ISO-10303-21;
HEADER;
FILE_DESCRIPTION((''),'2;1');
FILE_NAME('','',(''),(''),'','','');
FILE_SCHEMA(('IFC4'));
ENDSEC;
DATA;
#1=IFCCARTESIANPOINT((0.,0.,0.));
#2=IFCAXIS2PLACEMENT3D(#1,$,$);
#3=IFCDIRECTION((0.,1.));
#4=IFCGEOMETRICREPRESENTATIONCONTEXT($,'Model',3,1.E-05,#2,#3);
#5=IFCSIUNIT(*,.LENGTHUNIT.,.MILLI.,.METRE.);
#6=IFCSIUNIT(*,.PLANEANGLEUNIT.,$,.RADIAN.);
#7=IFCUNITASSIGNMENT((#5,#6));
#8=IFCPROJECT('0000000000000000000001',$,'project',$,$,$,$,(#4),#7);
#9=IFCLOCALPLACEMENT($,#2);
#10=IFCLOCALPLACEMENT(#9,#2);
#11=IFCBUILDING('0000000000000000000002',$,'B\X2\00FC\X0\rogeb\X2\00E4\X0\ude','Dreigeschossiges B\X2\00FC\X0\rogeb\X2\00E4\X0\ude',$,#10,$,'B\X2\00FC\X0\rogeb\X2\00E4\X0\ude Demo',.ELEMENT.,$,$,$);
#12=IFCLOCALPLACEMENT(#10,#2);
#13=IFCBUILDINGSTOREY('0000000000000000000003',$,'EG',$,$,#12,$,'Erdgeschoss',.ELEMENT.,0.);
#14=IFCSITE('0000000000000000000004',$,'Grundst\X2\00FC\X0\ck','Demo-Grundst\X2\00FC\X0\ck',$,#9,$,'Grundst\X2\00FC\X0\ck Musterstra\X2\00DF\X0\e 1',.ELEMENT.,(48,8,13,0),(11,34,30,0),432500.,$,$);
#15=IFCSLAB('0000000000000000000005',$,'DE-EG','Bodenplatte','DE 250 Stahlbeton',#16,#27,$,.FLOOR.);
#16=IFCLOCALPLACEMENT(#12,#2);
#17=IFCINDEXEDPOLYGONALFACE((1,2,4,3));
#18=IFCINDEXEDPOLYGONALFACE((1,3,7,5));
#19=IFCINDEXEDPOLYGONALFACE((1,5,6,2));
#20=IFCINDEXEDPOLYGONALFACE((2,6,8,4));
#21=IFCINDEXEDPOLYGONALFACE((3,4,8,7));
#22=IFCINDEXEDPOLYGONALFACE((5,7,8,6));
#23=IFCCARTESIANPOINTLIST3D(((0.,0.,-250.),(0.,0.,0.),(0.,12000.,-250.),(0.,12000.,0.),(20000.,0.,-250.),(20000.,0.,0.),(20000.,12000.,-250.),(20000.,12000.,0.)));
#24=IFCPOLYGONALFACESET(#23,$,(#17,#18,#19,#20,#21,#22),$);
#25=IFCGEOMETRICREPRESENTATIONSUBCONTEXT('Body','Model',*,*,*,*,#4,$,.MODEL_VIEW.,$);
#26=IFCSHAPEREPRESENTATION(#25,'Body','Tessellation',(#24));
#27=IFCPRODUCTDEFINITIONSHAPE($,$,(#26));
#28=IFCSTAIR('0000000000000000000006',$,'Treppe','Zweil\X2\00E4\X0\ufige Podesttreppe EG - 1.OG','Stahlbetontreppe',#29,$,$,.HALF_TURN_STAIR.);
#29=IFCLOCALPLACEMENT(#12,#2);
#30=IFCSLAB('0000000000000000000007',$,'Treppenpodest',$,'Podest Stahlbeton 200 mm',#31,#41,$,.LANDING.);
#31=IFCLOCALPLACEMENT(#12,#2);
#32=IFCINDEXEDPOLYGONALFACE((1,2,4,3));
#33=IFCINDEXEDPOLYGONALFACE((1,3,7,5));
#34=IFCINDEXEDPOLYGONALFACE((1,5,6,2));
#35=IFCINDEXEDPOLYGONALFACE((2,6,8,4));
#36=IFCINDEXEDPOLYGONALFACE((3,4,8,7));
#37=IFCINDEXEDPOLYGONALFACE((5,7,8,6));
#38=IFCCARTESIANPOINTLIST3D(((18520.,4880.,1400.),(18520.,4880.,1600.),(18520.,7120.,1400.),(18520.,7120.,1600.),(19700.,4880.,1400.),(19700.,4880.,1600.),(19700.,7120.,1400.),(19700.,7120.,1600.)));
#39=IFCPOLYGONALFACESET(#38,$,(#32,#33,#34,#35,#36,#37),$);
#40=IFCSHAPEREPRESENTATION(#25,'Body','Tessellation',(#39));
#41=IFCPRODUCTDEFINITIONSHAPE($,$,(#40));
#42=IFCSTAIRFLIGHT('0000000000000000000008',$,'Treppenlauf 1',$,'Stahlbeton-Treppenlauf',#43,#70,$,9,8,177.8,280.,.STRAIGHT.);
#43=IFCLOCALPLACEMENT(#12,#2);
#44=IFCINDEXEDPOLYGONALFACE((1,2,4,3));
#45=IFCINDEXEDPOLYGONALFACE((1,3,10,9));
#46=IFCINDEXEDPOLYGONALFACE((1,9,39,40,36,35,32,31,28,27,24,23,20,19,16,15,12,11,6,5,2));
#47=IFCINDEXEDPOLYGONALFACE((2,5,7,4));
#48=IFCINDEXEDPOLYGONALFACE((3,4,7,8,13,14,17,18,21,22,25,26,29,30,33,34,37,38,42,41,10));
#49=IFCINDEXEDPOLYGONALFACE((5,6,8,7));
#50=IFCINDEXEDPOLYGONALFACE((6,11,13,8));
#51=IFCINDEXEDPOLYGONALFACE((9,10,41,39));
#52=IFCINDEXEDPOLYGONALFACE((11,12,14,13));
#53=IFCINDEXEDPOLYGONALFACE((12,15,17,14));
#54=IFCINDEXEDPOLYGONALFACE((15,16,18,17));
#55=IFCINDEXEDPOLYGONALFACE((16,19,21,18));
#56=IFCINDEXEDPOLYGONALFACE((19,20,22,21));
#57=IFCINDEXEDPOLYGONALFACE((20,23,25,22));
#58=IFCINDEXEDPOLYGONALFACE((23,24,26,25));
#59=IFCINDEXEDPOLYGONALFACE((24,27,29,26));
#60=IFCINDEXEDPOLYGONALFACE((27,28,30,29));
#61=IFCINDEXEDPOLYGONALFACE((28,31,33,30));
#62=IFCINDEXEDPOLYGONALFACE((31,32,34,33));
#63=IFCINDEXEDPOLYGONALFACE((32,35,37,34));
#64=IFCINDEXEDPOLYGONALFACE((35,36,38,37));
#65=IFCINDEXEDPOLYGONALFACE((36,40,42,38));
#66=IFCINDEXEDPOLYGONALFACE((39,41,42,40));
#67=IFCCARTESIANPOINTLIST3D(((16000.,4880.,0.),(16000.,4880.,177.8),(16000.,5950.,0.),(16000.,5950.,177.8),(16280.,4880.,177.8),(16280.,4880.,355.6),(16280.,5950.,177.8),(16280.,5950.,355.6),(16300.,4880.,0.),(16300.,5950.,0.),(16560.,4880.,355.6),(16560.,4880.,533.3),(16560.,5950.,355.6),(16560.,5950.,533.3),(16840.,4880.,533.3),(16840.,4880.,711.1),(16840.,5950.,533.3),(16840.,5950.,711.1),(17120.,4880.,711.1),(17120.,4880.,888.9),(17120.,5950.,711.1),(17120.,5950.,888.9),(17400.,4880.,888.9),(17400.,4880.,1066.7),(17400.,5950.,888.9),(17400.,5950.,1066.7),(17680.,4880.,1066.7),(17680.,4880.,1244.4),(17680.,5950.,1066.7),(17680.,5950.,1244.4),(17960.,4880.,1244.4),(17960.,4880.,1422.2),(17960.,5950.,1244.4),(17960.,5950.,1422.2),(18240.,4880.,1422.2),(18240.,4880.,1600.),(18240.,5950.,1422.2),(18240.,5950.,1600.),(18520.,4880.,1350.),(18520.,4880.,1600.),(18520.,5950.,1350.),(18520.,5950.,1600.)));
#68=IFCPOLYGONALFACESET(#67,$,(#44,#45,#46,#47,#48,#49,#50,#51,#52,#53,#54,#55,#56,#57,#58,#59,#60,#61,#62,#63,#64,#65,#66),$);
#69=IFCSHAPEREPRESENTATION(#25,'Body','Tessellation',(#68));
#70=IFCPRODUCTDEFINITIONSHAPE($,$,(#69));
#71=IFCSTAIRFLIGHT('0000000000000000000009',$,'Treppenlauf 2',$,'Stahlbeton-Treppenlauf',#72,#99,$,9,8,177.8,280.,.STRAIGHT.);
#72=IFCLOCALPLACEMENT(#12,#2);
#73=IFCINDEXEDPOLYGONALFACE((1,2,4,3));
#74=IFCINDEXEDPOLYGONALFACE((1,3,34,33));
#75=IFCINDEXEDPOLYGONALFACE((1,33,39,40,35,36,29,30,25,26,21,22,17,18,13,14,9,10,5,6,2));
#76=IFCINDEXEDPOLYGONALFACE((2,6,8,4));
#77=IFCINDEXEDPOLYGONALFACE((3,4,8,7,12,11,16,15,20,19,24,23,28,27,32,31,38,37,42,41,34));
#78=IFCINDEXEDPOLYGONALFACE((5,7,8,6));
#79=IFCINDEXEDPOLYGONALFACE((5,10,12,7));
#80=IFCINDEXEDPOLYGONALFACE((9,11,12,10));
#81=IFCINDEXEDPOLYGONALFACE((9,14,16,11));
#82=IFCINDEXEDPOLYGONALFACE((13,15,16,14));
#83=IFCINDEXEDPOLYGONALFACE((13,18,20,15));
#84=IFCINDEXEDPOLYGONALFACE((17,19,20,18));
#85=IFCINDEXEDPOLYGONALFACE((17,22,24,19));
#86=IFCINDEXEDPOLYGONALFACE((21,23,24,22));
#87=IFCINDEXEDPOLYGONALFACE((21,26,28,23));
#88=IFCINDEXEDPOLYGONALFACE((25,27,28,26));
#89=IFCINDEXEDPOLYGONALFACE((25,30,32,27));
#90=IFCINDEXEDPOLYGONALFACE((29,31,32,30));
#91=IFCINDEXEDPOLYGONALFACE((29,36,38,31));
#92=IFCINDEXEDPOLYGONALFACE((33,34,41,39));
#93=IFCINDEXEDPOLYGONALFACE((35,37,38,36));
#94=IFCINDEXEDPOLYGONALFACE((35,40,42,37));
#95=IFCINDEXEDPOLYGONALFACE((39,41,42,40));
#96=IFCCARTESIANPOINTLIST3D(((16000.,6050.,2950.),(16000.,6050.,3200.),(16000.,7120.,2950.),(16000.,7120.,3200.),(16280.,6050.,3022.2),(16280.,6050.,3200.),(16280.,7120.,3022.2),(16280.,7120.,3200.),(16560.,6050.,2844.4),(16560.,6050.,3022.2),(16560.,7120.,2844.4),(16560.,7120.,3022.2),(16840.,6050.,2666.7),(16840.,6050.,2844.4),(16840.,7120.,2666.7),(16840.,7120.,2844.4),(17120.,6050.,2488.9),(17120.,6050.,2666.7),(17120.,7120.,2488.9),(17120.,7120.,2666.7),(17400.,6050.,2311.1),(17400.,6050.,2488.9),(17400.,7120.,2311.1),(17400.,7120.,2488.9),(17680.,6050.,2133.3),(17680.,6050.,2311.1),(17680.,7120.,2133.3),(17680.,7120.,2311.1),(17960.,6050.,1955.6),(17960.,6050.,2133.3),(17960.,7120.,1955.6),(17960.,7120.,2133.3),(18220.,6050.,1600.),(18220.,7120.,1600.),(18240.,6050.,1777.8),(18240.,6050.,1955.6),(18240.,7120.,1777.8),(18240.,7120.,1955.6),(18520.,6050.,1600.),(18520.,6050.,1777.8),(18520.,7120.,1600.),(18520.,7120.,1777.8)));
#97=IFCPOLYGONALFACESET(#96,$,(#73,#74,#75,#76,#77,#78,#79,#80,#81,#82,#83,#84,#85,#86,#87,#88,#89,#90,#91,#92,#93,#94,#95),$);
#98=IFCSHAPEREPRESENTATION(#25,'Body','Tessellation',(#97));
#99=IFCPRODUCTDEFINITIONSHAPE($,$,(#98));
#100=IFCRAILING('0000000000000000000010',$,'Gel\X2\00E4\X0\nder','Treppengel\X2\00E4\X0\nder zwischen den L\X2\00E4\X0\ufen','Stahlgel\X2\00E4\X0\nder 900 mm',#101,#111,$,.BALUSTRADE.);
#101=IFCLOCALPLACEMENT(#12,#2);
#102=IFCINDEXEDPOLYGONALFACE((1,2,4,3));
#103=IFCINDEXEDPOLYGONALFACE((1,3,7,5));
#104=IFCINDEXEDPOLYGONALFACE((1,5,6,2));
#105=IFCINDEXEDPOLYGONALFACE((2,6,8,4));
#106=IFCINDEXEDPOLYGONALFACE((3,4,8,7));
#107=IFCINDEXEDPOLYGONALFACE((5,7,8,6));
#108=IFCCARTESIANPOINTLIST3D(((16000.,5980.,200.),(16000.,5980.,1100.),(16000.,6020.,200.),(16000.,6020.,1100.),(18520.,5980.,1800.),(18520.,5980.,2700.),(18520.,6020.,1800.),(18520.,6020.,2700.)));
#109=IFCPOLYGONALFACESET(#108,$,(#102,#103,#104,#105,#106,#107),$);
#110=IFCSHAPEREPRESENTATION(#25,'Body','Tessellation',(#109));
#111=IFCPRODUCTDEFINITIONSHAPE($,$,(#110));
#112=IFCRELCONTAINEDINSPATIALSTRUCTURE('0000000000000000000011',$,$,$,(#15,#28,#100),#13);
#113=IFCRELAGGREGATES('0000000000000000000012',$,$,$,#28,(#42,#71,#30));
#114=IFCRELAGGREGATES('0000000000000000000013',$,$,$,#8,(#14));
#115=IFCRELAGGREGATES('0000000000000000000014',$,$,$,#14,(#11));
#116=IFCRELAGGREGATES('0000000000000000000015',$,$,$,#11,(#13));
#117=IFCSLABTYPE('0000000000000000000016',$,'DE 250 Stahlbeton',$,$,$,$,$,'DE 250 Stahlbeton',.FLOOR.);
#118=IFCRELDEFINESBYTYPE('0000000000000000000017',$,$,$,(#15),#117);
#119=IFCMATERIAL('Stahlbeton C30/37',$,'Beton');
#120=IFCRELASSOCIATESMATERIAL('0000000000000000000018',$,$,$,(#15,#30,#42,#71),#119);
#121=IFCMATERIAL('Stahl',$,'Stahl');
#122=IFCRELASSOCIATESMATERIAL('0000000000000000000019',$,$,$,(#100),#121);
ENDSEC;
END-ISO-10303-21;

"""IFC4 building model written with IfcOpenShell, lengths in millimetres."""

from ifc_helpers import new_model, si_unit, direction, frame, frame_2d, origin, place, context, subcontext, project, spatial, polyline, rectangle, outline, extrude, material, type_object, element, aggregate, save


model = new_model("IFC4")

# Units and contexts
model_context = context("Model", 3, precision=1e-05, world=origin(), true_north=direction((0.0, 1.0)))
body_context = subcontext(model_context, "Body", "Model", "MODEL_VIEW")
ifc_project = project(units=[si_unit("LENGTHUNIT", "METRE", prefix="MILLI"), si_unit("PLANEANGLEUNIT", "RADIAN")], contexts=[model_context])

# Site, building, storey
site_placement = place(None, origin())
site = spatial("IfcSite", under=ifc_project, at=site_placement, Name="Grundstück", Description="Demo-Grundstück", LongName="Grundstück Musterstraße 1", CompositionType="ELEMENT", RefLatitude=(48, 8, 13, 0), RefLongitude=(11, 34, 30, 0), RefElevation=432500.0)
building_placement = place(site_placement, origin())
building = spatial("IfcBuilding", under=site, at=building_placement, Name="Bürogebäude", Description="Dreigeschossiges Bürogebäude", LongName="Bürogebäude Demo", CompositionType="ELEMENT")
storey_placement = place(building_placement, origin())
storey = spatial("IfcBuildingStorey", under=building, at=storey_placement, Name="EG", LongName="Erdgeschoss", CompositionType="ELEMENT", Elevation=0.0)

# Slab
ifc_material_1 = material(Name="Stahlbeton C30/37", Category="Beton")
slab_type = type_object("IfcSlabType", Name="DE 250 Stahlbeton", ElementType="DE 250 Stahlbeton", PredefinedType="FLOOR")
slab_1_placement = place(storey_placement, origin())
element("IfcSlab", 1, at=slab_1_placement, inside=storey, type_object=slab_type, material=ifc_material_1, Name="DE-EG", Description="Bodenplatte", ObjectType="DE 250 Stahlbeton", PredefinedType="FLOOR", context=body_context, shape_type="SweptSolid", body=[
    extrude(rectangle(XDim=20000.0, YDim=12000.0, at=frame_2d((10000.0, 6000.0))), frame((0.0, 0.0, -250.0)), (0.0, 0.0, 1.0), 250.0),
])

# Stair, slab, stair flights
stair_placement = place(storey_placement, origin())
stair = element("IfcStair", 2, at=stair_placement, inside=storey, Name="Treppe", Description="Zweiläufige Podesttreppe EG - 1.OG", ObjectType="Stahlbetontreppe", PredefinedType="HALF_TURN_STAIR")
slab_2_placement = place(stair_placement, origin())
slab_2 = element("IfcSlab", 3, at=slab_2_placement, material=ifc_material_1, Name="Treppenpodest", ObjectType="Podest Stahlbeton 200 mm", PredefinedType="LANDING", context=body_context, shape_type="SweptSolid", body=[
    extrude(rectangle(XDim=1180.0, YDim=2240.0, at=frame_2d((19110.0, 6000.0))), frame((0.0, 0.0, 1400.0)), (0.0, 0.0, 1.0), 200.0),
])
stair_flight_1_placement = place(stair_placement, origin())
stair_flight_1 = element("IfcStairFlight", 4, at=stair_flight_1_placement, material=ifc_material_1, Name="Treppenlauf 1", ObjectType="Stahlbeton-Treppenlauf", NumberOfRisers=9, NumberOfTreads=8, PredefinedType="STRAIGHT", RiserHeight=177.8, TreadLength=280.0, context=body_context, shape_type="SweptSolid", body=[
    extrude(outline(polyline([(16300.0, 0.0), (18520.0, 1350.0), (18520.0, 1600.0), (18240.0, 1600.0), (18240.0, 1422.2), (17960.0, 1422.2), (17960.0, 1244.4), (17680.0, 1244.4), (17680.0, 1066.7), (17400.0, 1066.7), (17400.0, 888.9), (17120.0, 888.9), (17120.0, 711.1), (16840.0, 711.1), (16840.0, 533.3), (16560.0, 533.3), (16560.0, 355.6), (16280.0, 355.6), (16280.0, 177.8), (16000.0, 177.8), (16000.0, 0.0), (16300.0, 0.0)])), frame((0.0, 5950.0, 0.0), z_axis=(0.0, -1.0, 0.0), x_axis=(1.0, 0.0, 0.0)), (0.0, 0.0, 1.0), 1070.0),
])
stair_flight_2_placement = place(stair_placement, origin())
stair_flight_2 = element("IfcStairFlight", 5, at=stair_flight_2_placement, material=ifc_material_1, Name="Treppenlauf 2", ObjectType="Stahlbeton-Treppenlauf", NumberOfRisers=9, NumberOfTreads=8, PredefinedType="STRAIGHT", RiserHeight=177.8, TreadLength=280.0, context=body_context, shape_type="SweptSolid", body=[
    extrude(outline(polyline([(18520.0, 1600.0), (18520.0, 1777.8), (18240.0, 1777.8), (18240.0, 1955.6), (17960.0, 1955.6), (17960.0, 2133.3), (17680.0, 2133.3), (17680.0, 2311.1), (17400.0, 2311.1), (17400.0, 2488.9), (17120.0, 2488.9), (17120.0, 2666.7), (16840.0, 2666.7), (16840.0, 2844.4), (16560.0, 2844.4), (16560.0, 3022.2), (16280.0, 3022.2), (16280.0, 3200.0), (16000.0, 3200.0), (16000.0, 2950.0), (18220.0, 1600.0), (18520.0, 1600.0)])), frame((0.0, 7120.0, 0.0), z_axis=(0.0, -1.0, 0.0), x_axis=(1.0, 0.0, 0.0)), (0.0, 0.0, 1.0), 1070.0),
])
aggregate(stair, [stair_flight_1, stair_flight_2, slab_2])

# Railing
ifc_material_2 = material(Name="Stahl", Category="Stahl")
railing_placement = place(storey_placement, origin())
element("IfcRailing", 6, at=railing_placement, inside=storey, material=ifc_material_2, Name="Geländer", Description="Treppengeländer zwischen den Läufen", ObjectType="Stahlgeländer 900 mm", PredefinedType="BALUSTRADE", context=body_context, shape_type="SweptSolid", body=[
    extrude(outline(polyline([(16000.0, 200.0), (18520.0, 1800.0), (18520.0, 2700.0), (16000.0, 1100.0), (16000.0, 200.0)])), frame((0.0, 6020.0, 0.0), z_axis=(0.0, -1.0, 0.0), x_axis=(1.0, 0.0, 0.0)), (0.0, 0.0, 1.0), 40.0),
])

save(model, "model.ifc")
